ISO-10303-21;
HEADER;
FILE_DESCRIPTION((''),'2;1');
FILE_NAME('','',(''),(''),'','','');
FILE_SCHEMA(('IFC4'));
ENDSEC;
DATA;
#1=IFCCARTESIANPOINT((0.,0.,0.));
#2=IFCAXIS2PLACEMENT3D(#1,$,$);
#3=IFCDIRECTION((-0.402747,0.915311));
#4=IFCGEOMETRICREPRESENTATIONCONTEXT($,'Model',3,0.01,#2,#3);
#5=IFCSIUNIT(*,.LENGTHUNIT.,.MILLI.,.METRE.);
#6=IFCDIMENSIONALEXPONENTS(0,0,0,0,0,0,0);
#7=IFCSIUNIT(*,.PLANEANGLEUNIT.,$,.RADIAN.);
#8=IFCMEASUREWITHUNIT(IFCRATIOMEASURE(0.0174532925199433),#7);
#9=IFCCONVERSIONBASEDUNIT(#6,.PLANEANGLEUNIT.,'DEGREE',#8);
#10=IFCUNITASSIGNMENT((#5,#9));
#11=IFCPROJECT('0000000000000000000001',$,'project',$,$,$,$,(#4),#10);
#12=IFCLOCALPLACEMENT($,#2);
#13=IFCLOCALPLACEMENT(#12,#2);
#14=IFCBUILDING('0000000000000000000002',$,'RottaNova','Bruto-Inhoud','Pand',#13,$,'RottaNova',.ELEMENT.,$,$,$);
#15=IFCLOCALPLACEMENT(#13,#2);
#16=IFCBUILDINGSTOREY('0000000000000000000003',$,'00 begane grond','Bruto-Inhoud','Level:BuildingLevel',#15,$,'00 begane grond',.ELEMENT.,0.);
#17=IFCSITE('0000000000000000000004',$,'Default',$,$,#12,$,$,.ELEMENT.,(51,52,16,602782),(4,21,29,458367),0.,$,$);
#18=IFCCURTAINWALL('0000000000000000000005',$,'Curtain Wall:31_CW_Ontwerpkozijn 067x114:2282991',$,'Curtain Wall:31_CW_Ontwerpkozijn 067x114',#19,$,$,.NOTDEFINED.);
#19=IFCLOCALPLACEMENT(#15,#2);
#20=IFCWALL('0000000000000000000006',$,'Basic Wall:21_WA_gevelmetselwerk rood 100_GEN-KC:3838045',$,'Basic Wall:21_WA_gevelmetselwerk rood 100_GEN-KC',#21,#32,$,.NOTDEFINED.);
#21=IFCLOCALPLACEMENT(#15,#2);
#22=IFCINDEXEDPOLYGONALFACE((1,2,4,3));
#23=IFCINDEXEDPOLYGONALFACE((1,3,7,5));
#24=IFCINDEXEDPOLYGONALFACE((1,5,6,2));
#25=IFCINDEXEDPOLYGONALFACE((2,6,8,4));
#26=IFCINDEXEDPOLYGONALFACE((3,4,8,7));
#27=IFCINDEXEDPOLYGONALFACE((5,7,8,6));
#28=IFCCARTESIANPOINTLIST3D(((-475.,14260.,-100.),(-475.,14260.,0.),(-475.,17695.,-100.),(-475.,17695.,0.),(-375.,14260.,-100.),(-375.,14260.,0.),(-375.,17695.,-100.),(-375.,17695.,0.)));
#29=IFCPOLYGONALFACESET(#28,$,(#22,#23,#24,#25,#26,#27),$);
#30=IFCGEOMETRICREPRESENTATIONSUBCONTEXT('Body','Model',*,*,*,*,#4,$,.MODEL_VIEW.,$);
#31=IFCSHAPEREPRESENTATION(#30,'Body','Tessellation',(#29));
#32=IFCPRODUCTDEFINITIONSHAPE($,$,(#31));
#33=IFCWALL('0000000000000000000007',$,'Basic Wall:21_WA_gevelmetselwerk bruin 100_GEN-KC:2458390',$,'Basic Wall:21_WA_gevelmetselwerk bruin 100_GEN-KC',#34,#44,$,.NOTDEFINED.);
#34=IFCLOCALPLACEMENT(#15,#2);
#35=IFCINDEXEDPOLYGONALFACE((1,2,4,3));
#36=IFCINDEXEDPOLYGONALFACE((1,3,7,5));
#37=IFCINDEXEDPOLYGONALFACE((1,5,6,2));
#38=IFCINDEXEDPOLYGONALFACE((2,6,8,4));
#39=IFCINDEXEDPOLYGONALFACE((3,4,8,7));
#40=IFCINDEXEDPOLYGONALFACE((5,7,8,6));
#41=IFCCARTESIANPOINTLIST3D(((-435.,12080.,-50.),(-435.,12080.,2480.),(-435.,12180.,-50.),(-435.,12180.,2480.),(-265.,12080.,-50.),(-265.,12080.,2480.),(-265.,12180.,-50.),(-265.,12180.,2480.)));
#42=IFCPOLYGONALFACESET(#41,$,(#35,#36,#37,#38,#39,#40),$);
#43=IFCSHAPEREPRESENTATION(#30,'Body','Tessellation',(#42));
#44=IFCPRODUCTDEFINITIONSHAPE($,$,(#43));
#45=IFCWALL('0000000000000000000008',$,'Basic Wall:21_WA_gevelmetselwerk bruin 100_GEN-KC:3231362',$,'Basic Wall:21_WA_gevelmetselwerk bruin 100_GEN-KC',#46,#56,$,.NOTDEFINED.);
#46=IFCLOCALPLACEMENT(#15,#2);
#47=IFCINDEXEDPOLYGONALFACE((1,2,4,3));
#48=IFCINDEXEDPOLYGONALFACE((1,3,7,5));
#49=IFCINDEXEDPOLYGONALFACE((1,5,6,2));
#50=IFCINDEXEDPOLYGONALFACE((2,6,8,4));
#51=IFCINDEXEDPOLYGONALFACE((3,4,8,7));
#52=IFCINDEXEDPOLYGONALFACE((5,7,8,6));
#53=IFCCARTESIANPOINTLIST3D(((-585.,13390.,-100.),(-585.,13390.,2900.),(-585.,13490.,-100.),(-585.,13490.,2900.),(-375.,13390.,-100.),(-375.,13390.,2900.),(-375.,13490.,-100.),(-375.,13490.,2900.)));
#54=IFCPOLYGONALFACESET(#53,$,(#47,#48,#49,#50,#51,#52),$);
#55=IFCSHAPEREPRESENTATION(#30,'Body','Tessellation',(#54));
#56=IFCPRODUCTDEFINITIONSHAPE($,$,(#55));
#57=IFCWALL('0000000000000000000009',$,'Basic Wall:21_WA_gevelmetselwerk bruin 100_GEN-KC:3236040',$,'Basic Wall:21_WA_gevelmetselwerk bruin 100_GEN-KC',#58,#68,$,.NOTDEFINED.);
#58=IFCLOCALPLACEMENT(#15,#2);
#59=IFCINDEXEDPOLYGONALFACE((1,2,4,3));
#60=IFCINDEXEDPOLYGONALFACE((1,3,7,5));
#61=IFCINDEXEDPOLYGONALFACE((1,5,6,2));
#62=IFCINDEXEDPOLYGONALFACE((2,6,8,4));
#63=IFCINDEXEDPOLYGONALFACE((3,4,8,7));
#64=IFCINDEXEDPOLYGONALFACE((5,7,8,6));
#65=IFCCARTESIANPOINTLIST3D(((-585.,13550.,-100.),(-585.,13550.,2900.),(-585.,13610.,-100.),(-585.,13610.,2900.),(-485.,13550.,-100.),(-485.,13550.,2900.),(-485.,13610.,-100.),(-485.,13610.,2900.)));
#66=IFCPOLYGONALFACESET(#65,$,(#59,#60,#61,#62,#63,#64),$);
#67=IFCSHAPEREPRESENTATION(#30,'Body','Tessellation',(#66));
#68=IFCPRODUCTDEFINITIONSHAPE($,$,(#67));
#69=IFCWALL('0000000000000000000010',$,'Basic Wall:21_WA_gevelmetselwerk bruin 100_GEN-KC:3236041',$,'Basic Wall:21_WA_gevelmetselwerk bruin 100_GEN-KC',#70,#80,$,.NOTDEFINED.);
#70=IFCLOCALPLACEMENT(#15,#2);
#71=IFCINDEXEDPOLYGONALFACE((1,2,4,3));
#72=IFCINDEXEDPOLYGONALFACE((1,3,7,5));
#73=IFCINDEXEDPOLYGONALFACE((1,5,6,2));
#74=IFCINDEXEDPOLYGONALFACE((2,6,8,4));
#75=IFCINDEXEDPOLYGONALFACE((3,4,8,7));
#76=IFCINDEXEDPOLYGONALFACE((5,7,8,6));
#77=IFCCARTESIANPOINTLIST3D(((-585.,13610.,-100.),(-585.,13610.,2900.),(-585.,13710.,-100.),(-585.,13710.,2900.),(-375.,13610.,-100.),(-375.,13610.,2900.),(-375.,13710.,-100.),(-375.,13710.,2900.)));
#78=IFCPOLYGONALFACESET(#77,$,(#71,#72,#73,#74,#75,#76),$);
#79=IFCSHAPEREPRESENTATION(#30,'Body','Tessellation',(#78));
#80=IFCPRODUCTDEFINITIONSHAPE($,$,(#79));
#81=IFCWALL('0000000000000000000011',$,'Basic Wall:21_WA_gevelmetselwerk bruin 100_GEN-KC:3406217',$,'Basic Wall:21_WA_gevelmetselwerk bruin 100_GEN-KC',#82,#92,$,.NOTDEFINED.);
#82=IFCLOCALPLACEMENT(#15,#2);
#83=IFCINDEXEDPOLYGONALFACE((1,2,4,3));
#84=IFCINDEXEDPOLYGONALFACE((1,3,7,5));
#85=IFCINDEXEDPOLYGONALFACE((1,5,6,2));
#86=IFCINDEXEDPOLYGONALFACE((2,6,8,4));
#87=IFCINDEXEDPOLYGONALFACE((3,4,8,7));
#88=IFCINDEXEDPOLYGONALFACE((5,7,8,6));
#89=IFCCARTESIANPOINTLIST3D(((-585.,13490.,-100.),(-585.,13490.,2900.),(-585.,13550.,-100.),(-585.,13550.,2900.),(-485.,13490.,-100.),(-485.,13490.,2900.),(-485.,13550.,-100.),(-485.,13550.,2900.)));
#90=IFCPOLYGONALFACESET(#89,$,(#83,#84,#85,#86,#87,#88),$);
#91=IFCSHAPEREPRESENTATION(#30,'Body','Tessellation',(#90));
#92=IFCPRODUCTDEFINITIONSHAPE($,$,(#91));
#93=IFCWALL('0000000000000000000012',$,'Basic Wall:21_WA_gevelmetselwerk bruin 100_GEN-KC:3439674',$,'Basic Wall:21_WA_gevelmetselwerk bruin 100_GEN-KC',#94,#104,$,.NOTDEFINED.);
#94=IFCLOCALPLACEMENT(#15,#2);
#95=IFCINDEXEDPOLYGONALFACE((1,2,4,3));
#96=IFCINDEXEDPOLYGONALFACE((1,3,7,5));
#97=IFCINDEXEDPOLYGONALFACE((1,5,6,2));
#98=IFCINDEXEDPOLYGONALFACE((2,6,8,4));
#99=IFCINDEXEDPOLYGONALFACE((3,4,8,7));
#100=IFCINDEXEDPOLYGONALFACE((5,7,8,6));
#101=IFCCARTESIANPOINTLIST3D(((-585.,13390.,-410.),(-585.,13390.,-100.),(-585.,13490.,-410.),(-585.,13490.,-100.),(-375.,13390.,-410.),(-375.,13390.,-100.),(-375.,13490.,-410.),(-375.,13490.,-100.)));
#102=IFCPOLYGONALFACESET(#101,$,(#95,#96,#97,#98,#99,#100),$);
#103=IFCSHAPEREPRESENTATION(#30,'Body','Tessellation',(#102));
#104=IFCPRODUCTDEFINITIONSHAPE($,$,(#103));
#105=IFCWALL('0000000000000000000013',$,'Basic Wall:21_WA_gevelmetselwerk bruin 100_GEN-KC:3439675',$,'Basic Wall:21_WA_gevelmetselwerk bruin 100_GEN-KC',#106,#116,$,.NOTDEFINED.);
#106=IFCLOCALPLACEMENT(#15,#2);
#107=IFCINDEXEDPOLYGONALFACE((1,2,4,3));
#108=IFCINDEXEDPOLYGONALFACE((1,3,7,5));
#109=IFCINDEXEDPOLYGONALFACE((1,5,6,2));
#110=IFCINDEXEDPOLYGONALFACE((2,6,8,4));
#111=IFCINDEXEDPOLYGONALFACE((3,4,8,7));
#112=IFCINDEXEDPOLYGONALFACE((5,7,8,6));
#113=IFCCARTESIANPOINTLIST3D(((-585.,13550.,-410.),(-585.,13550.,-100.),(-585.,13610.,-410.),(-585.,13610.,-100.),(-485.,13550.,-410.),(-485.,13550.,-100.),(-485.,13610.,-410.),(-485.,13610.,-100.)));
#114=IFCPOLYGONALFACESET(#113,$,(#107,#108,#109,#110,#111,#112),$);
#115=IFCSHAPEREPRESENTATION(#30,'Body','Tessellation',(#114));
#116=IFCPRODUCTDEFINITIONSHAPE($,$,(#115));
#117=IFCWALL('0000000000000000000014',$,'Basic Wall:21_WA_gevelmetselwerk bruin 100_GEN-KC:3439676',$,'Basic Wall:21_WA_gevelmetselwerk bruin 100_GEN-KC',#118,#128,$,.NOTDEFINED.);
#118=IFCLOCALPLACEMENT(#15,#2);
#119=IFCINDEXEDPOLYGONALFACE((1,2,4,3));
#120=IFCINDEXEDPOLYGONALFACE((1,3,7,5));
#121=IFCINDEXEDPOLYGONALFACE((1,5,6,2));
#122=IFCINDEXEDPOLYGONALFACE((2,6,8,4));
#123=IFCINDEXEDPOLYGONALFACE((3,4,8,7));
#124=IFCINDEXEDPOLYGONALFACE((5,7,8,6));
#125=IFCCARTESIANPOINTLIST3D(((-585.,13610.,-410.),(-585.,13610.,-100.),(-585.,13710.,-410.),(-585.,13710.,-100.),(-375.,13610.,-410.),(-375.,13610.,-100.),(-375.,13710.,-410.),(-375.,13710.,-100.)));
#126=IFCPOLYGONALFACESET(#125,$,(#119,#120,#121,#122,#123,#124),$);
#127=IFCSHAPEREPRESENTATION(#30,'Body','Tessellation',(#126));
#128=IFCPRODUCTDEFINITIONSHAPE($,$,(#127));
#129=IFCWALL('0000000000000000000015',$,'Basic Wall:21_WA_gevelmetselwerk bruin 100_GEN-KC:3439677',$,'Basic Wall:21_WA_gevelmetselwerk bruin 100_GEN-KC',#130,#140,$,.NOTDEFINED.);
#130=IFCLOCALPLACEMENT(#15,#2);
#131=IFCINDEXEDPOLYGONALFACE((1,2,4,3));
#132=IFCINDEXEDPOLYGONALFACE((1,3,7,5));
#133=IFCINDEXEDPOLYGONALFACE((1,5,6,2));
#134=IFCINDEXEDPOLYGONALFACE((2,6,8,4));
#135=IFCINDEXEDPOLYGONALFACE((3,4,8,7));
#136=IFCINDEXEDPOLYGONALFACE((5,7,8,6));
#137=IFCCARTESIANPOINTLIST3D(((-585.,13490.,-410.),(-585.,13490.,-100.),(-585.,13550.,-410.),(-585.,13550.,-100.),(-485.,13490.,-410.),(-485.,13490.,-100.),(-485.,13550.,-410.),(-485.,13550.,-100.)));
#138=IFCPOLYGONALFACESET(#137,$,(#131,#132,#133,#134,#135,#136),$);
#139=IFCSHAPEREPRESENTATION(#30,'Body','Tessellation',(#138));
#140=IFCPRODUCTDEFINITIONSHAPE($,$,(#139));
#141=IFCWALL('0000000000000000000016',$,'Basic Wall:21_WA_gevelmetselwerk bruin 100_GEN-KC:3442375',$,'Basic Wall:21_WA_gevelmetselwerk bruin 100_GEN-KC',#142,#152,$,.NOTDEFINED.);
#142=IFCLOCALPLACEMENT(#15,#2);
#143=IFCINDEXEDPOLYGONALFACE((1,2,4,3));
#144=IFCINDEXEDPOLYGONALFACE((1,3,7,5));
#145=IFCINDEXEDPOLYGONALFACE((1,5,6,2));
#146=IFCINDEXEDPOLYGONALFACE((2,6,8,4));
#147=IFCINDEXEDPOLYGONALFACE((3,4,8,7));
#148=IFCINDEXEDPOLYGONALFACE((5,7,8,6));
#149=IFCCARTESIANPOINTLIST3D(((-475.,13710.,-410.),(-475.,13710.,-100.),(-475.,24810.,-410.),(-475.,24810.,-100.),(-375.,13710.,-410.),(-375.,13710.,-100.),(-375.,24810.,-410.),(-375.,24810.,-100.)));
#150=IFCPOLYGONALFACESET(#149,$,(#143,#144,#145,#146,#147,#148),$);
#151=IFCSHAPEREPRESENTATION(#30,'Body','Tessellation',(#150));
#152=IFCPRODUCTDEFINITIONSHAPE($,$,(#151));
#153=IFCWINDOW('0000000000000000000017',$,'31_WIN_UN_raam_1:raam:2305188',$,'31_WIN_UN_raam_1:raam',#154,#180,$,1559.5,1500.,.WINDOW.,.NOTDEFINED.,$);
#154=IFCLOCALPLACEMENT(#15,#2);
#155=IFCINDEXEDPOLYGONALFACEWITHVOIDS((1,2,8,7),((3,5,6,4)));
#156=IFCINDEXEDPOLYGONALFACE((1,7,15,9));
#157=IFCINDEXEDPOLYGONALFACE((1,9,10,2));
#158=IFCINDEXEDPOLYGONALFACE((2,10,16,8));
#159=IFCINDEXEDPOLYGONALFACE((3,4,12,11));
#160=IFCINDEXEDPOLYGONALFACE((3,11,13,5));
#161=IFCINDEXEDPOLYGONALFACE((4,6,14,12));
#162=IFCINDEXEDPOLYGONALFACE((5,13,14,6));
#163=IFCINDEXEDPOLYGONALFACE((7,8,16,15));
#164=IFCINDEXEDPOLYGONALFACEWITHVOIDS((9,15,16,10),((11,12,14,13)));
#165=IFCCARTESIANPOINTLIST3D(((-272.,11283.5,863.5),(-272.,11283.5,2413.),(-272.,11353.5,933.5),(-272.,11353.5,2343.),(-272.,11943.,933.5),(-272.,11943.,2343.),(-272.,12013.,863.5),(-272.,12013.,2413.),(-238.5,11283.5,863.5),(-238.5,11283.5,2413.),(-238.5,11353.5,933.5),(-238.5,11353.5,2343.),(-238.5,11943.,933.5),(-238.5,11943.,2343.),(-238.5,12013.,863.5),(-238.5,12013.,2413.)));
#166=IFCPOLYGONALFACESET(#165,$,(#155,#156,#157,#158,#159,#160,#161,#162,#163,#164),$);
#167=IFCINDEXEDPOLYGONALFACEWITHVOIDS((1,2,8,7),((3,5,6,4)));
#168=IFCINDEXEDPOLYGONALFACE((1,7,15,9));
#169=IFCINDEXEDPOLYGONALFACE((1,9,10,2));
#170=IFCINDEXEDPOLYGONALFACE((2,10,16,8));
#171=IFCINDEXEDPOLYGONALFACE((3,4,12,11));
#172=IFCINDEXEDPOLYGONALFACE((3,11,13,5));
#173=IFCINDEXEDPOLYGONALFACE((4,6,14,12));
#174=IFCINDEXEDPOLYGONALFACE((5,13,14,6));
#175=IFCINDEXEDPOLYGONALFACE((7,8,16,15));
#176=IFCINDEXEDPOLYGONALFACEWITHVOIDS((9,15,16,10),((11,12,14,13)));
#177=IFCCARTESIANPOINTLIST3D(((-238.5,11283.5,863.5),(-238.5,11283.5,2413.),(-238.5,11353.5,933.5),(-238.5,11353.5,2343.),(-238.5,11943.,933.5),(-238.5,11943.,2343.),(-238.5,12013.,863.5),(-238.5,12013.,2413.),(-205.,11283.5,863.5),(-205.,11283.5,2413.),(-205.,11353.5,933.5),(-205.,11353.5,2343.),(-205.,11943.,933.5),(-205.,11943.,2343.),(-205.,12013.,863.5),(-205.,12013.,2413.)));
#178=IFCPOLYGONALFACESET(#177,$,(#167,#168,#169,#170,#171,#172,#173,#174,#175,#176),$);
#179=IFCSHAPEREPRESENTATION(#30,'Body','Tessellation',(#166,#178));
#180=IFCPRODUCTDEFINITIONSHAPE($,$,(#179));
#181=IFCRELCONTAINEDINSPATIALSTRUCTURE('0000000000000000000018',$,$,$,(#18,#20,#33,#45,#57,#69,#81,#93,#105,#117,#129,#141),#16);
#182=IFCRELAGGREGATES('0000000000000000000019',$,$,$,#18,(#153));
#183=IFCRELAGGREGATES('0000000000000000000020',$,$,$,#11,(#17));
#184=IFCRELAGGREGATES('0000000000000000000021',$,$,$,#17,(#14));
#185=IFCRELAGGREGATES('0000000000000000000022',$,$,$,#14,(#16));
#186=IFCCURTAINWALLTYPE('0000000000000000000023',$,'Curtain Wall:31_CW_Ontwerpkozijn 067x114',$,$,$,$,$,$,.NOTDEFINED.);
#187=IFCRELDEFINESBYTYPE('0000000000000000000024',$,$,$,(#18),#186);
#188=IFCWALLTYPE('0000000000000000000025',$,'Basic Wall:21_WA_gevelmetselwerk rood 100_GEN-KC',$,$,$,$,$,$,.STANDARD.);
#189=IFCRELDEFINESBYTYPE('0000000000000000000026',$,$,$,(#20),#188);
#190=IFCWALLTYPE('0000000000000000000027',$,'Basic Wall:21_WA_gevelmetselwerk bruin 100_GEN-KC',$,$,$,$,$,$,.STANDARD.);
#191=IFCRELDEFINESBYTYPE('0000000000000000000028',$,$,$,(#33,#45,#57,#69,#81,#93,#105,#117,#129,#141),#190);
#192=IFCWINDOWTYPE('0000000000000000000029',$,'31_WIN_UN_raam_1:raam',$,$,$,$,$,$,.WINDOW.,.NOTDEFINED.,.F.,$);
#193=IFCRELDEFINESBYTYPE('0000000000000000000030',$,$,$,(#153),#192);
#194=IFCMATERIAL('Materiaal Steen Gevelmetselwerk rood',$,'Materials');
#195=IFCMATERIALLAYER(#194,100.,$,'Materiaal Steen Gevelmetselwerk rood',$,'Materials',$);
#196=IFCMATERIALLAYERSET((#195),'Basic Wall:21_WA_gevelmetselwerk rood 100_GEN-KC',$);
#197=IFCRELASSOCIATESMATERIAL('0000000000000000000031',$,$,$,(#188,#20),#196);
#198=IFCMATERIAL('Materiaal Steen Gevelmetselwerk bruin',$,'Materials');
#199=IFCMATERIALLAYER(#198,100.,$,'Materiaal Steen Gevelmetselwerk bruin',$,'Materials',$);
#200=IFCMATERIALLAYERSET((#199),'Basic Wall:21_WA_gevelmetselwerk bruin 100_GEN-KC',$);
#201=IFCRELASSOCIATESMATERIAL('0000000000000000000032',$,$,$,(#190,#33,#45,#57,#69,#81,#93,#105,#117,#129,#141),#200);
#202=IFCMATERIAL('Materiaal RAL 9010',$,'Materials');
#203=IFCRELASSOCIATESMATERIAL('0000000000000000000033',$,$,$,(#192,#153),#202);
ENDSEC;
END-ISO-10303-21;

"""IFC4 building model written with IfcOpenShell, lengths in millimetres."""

from ifc_helpers import new_model, entity, si_unit, converted_unit, direction, frame, frame_2d, origin, place, context, subcontext, project, spatial, polyline, rectangle, outline, extrude, source, transform, mapped, material, layer, layer_set, type_object, type_shapes, element, aggregate, save


model = new_model("IFC4")

# Units and contexts
model_context = context("Model", 3, precision=0.01, world=origin(), true_north=direction((-0.402747, 0.915311)))
body_context = subcontext(model_context, "Body", "Model", "MODEL_VIEW")
ifc_project = project(units=[si_unit("LENGTHUNIT", "METRE", prefix="MILLI"), converted_unit("PLANEANGLEUNIT", "DEGREE", entity("IfcRatioMeasure", 0.0174532925199433), si_unit("PLANEANGLEUNIT", "RADIAN"), dimensions=[0, 0, 0, 0, 0, 0, 0])], contexts=[model_context])

# Site, building, storey
site_placement = place(None, origin())
site = spatial("IfcSite", under=ifc_project, at=site_placement, Name="Default", CompositionType="ELEMENT", RefLatitude=(51, 52, 16, 602782), RefLongitude=(4, 21, 29, 458367), RefElevation=0.0)
building_placement = place(site_placement, origin())
building = spatial("IfcBuilding", under=site, at=building_placement, Name="RottaNova", Description="Bruto-Inhoud", ObjectType="Pand", LongName="RottaNova", CompositionType="ELEMENT")
storey_placement = place(building_placement, origin())
storey = spatial("IfcBuildingStorey", under=building, at=storey_placement, Name="00 begane grond", Description="Bruto-Inhoud", ObjectType="Level:BuildingLevel", LongName="00 begane grond", CompositionType="ELEMENT", Elevation=0.0)

# Curtain wall
curtain_wall_type = type_object("IfcCurtainWallType", Name="Curtain Wall:31_CW_Ontwerpkozijn 067x114", PredefinedType="NOTDEFINED")
curtain_wall_1_placement = place(storey_placement, origin())
curtain_wall_1 = element("IfcCurtainWall", 1, at=curtain_wall_1_placement, inside=storey, type_object=curtain_wall_type, Name="Curtain Wall:31_CW_Ontwerpkozijn 067x114:2282991", ObjectType="Curtain Wall:31_CW_Ontwerpkozijn 067x114", PredefinedType="NOTDEFINED")

# Wall
ifc_material_1 = material(Name="Materiaal Steen Gevelmetselwerk rood", Category="Materials")
ifc_layer_1 = layer(ifc_material_1, 100.0, Name="Materiaal Steen Gevelmetselwerk rood", Category="Materials")
ifc_layer_set_1 = layer_set([ifc_layer_1], Name="Basic Wall:21_WA_gevelmetselwerk rood 100_GEN-KC")
wall_type_1 = type_object("IfcWallType", Name="Basic Wall:21_WA_gevelmetselwerk rood 100_GEN-KC", PredefinedType="STANDARD", material=ifc_layer_set_1)
wall_1_placement = place(storey_placement, frame((-425.0, 14260.0, -100.0), z_axis=(0.0, 0.0, 1.0), x_axis=(0.0, 1.0, 0.0)))
element("IfcWall", 2, at=wall_1_placement, inside=storey, type_object=wall_type_1, material=ifc_layer_set_1, Name="Basic Wall:21_WA_gevelmetselwerk rood 100_GEN-KC:3838045", ObjectType="Basic Wall:21_WA_gevelmetselwerk rood 100_GEN-KC", PredefinedType="NOTDEFINED", context=body_context, shape_type="SweptSolid", body=[
    extrude(rectangle(XDim=3435.0, YDim=100.0, at=frame_2d((1717.5, 0.0), x_axis=(-1.0, 0.0))), origin(), (0.0, 0.0, 1.0), 100.0),
])

# Shared definitions
ifc_material_2 = material(Name="Materiaal Steen Gevelmetselwerk bruin", Category="Materials")
ifc_layer_2 = layer(ifc_material_2, 100.0, Name="Materiaal Steen Gevelmetselwerk bruin", Category="Materials")
ifc_layer_set_2 = layer_set([ifc_layer_2], Name="Basic Wall:21_WA_gevelmetselwerk bruin 100_GEN-KC")
wall_type_2 = type_object("IfcWallType", Name="Basic Wall:21_WA_gevelmetselwerk bruin 100_GEN-KC", PredefinedType="STANDARD", material=ifc_layer_set_2)

# Walls
wall_2_placement = place(storey_placement, frame((-435.0, 12130.0, -50.0)))
element("IfcWall", 3, at=wall_2_placement, inside=storey, type_object=wall_type_2, material=ifc_layer_set_2, Name="Basic Wall:21_WA_gevelmetselwerk bruin 100_GEN-KC:2458390", ObjectType="Basic Wall:21_WA_gevelmetselwerk bruin 100_GEN-KC", PredefinedType="NOTDEFINED", context=body_context, shape_type="SweptSolid", body=[
    extrude(rectangle(XDim=170.0, YDim=100.0, at=frame_2d((85.0, 0.0), x_axis=(-1.0, 0.0))), origin(), (0.0, 0.0, 1.0), 2530.0),
])
wall_3_placement = place(storey_placement, frame((-585.0, 13440.0, -100.0)))
element("IfcWall", 4, at=wall_3_placement, inside=storey, type_object=wall_type_2, material=ifc_layer_set_2, Name="Basic Wall:21_WA_gevelmetselwerk bruin 100_GEN-KC:3231362", ObjectType="Basic Wall:21_WA_gevelmetselwerk bruin 100_GEN-KC", PredefinedType="NOTDEFINED", context=body_context, shape_type="SweptSolid", body=[
    extrude(rectangle(XDim=210.0, YDim=100.0, at=frame_2d((105.0, 0.0), x_axis=(-1.0, 0.0))), origin(), (0.0, 0.0, 1.0), 3000.0),
])
wall_4_placement = place(storey_placement, frame((-535.0, 13550.0, -100.0), z_axis=(0.0, 0.0, 1.0), x_axis=(0.0, 1.0, 0.0)))
element("IfcWall", 5, at=wall_4_placement, inside=storey, type_object=wall_type_2, material=ifc_layer_set_2, Name="Basic Wall:21_WA_gevelmetselwerk bruin 100_GEN-KC:3236040", ObjectType="Basic Wall:21_WA_gevelmetselwerk bruin 100_GEN-KC", PredefinedType="NOTDEFINED", context=body_context, shape_type="SweptSolid", body=[
    extrude(rectangle(XDim=60.0, YDim=100.0, at=frame_2d((30.0, 0.0), x_axis=(-1.0, 0.0))), origin(), (0.0, 0.0, 1.0), 3000.0),
])
wall_5_placement = place(storey_placement, frame((-585.0, 13660.0, -100.0)))
element("IfcWall", 6, at=wall_5_placement, inside=storey, type_object=wall_type_2, material=ifc_layer_set_2, Name="Basic Wall:21_WA_gevelmetselwerk bruin 100_GEN-KC:3236041", ObjectType="Basic Wall:21_WA_gevelmetselwerk bruin 100_GEN-KC", PredefinedType="NOTDEFINED", context=body_context, shape_type="SweptSolid", body=[
    extrude(rectangle(XDim=210.0, YDim=100.0, at=frame_2d((105.0, 0.0), x_axis=(-1.0, 0.0))), origin(), (0.0, 0.0, 1.0), 3000.0),
])
wall_6_placement = place(storey_placement, frame((-535.0, 13490.0, -100.0), z_axis=(0.0, 0.0, 1.0), x_axis=(0.0, 1.0, 0.0)))
element("IfcWall", 7, at=wall_6_placement, inside=storey, type_object=wall_type_2, material=ifc_layer_set_2, Name="Basic Wall:21_WA_gevelmetselwerk bruin 100_GEN-KC:3406217", ObjectType="Basic Wall:21_WA_gevelmetselwerk bruin 100_GEN-KC", PredefinedType="NOTDEFINED", context=body_context, shape_type="SweptSolid", body=[
    extrude(rectangle(XDim=60.0, YDim=100.0, at=frame_2d((30.0, 0.0), x_axis=(-1.0, 0.0))), origin(), (0.0, 0.0, 1.0), 3000.0),
])
wall_7_placement = place(storey_placement, frame((-585.0, 13440.0, -410.0)))
element("IfcWall", 8, at=wall_7_placement, inside=storey, type_object=wall_type_2, material=ifc_layer_set_2, Name="Basic Wall:21_WA_gevelmetselwerk bruin 100_GEN-KC:3439674", ObjectType="Basic Wall:21_WA_gevelmetselwerk bruin 100_GEN-KC", PredefinedType="NOTDEFINED", context=body_context, shape_type="SweptSolid", body=[
    extrude(rectangle(XDim=210.0, YDim=100.0, at=frame_2d((105.0, 0.0), x_axis=(-1.0, 0.0))), origin(), (0.0, 0.0, 1.0), 310.0),
])
wall_8_placement = place(storey_placement, frame((-535.0, 13550.0, -410.0), z_axis=(0.0, 0.0, 1.0), x_axis=(0.0, 1.0, 0.0)))
element("IfcWall", 9, at=wall_8_placement, inside=storey, type_object=wall_type_2, material=ifc_layer_set_2, Name="Basic Wall:21_WA_gevelmetselwerk bruin 100_GEN-KC:3439675", ObjectType="Basic Wall:21_WA_gevelmetselwerk bruin 100_GEN-KC", PredefinedType="NOTDEFINED", context=body_context, shape_type="SweptSolid", body=[
    extrude(rectangle(XDim=60.0, YDim=100.0, at=frame_2d((30.0, 0.0), x_axis=(-1.0, 0.0))), origin(), (0.0, 0.0, 1.0), 310.0),
])
wall_9_placement = place(storey_placement, frame((-585.0, 13660.0, -410.0)))
element("IfcWall", 10, at=wall_9_placement, inside=storey, type_object=wall_type_2, material=ifc_layer_set_2, Name="Basic Wall:21_WA_gevelmetselwerk bruin 100_GEN-KC:3439676", ObjectType="Basic Wall:21_WA_gevelmetselwerk bruin 100_GEN-KC", PredefinedType="NOTDEFINED", context=body_context, shape_type="SweptSolid", body=[
    extrude(rectangle(XDim=210.0, YDim=100.0, at=frame_2d((105.0, 0.0), x_axis=(-1.0, 0.0))), origin(), (0.0, 0.0, 1.0), 310.0),
])
wall_10_placement = place(storey_placement, frame((-535.0, 13490.0, -410.0), z_axis=(0.0, 0.0, 1.0), x_axis=(0.0, 1.0, 0.0)))
element("IfcWall", 11, at=wall_10_placement, inside=storey, type_object=wall_type_2, material=ifc_layer_set_2, Name="Basic Wall:21_WA_gevelmetselwerk bruin 100_GEN-KC:3439677", ObjectType="Basic Wall:21_WA_gevelmetselwerk bruin 100_GEN-KC", PredefinedType="NOTDEFINED", context=body_context, shape_type="SweptSolid", body=[
    extrude(rectangle(XDim=60.0, YDim=100.0, at=frame_2d((30.0, 0.0), x_axis=(-1.0, 0.0))), origin(), (0.0, 0.0, 1.0), 310.0),
])
wall_11_placement = place(storey_placement, frame((-425.0, 13710.0, -410.0), z_axis=(0.0, 0.0, 1.0), x_axis=(0.0, 1.0, 0.0)))
element("IfcWall", 12, at=wall_11_placement, inside=storey, type_object=wall_type_2, material=ifc_layer_set_2, Name="Basic Wall:21_WA_gevelmetselwerk bruin 100_GEN-KC:3442375", ObjectType="Basic Wall:21_WA_gevelmetselwerk bruin 100_GEN-KC", PredefinedType="NOTDEFINED", context=body_context, shape_type="SweptSolid", body=[
    extrude(rectangle(XDim=11100.0, YDim=100.0, at=frame_2d((5550.0, 0.0), x_axis=(-1.0, 0.0))), origin(), (0.0, 0.0, 1.0), 310.0),
])

# Window
ifc_material_3 = material(Name="Materiaal RAL 9010", Category="Materials")
window_type_1 = type_object("IfcWindowType", Name="31_WIN_UN_raam_1:raam", ParameterTakesPrecedence=False, PartitioningType="NOTDEFINED", PredefinedType="WINDOW", material=ifc_material_3)
shared_shape_1 = source(origin(), body_context, "Body", "SweptSolid", [
    extrude(outline(polyline([(-364.7, -774.7), (364.7, -774.7), (364.7, 774.7), (-364.7, 774.7), (-364.7, -774.7)]), holes=[polyline([(-294.7, 704.7), (294.7, 704.7), (294.7, -704.8), (-294.7, -704.8), (-294.7, 704.7)])]), frame((0.0, 58.5, 774.8), z_axis=(0.0, 1.0, 0.0), x_axis=(1.0, 0.0, 0.0)), (0.0, 0.0, 1.0), 33.5),
    extrude(outline(polyline([(-364.7, -774.7), (364.7, -774.7), (364.7, 774.7), (-364.7, 774.7), (-364.7, -774.7)]), holes=[polyline([(-294.7, 704.7), (294.7, 704.7), (294.7, -704.8), (-294.7, -704.8), (-294.7, 704.7)])]), frame((0.0, 25.0, 774.8), z_axis=(0.0, 1.0, 0.0), x_axis=(1.0, 0.0, 0.0)), (0.0, 0.0, 1.0), 33.5),
])
type_shapes(window_type_1, [shared_shape_1])
window_1_placement = place(curtain_wall_1_placement, frame((-180.0, 11648.2, 863.5), z_axis=(0.0, 0.0, 1.0), x_axis=(0.0, 1.0, 0.0)))
window_1 = element("IfcWindow", 13, at=window_1_placement, type_object=window_type_1, material=ifc_material_3, Name="31_WIN_UN_raam_1:raam:2305188", ObjectType="31_WIN_UN_raam_1:raam", OverallHeight=1559.5, OverallWidth=1500.0, PartitioningType="NOTDEFINED", PredefinedType="WINDOW", context=body_context, shape_type="MappedRepresentation", body=[
    mapped(shared_shape_1, transform((0.0, 0.0, 0.0), scale=1.0)),
])
aggregate(curtain_wall_1, [window_1])

save(model, "model.ifc")
